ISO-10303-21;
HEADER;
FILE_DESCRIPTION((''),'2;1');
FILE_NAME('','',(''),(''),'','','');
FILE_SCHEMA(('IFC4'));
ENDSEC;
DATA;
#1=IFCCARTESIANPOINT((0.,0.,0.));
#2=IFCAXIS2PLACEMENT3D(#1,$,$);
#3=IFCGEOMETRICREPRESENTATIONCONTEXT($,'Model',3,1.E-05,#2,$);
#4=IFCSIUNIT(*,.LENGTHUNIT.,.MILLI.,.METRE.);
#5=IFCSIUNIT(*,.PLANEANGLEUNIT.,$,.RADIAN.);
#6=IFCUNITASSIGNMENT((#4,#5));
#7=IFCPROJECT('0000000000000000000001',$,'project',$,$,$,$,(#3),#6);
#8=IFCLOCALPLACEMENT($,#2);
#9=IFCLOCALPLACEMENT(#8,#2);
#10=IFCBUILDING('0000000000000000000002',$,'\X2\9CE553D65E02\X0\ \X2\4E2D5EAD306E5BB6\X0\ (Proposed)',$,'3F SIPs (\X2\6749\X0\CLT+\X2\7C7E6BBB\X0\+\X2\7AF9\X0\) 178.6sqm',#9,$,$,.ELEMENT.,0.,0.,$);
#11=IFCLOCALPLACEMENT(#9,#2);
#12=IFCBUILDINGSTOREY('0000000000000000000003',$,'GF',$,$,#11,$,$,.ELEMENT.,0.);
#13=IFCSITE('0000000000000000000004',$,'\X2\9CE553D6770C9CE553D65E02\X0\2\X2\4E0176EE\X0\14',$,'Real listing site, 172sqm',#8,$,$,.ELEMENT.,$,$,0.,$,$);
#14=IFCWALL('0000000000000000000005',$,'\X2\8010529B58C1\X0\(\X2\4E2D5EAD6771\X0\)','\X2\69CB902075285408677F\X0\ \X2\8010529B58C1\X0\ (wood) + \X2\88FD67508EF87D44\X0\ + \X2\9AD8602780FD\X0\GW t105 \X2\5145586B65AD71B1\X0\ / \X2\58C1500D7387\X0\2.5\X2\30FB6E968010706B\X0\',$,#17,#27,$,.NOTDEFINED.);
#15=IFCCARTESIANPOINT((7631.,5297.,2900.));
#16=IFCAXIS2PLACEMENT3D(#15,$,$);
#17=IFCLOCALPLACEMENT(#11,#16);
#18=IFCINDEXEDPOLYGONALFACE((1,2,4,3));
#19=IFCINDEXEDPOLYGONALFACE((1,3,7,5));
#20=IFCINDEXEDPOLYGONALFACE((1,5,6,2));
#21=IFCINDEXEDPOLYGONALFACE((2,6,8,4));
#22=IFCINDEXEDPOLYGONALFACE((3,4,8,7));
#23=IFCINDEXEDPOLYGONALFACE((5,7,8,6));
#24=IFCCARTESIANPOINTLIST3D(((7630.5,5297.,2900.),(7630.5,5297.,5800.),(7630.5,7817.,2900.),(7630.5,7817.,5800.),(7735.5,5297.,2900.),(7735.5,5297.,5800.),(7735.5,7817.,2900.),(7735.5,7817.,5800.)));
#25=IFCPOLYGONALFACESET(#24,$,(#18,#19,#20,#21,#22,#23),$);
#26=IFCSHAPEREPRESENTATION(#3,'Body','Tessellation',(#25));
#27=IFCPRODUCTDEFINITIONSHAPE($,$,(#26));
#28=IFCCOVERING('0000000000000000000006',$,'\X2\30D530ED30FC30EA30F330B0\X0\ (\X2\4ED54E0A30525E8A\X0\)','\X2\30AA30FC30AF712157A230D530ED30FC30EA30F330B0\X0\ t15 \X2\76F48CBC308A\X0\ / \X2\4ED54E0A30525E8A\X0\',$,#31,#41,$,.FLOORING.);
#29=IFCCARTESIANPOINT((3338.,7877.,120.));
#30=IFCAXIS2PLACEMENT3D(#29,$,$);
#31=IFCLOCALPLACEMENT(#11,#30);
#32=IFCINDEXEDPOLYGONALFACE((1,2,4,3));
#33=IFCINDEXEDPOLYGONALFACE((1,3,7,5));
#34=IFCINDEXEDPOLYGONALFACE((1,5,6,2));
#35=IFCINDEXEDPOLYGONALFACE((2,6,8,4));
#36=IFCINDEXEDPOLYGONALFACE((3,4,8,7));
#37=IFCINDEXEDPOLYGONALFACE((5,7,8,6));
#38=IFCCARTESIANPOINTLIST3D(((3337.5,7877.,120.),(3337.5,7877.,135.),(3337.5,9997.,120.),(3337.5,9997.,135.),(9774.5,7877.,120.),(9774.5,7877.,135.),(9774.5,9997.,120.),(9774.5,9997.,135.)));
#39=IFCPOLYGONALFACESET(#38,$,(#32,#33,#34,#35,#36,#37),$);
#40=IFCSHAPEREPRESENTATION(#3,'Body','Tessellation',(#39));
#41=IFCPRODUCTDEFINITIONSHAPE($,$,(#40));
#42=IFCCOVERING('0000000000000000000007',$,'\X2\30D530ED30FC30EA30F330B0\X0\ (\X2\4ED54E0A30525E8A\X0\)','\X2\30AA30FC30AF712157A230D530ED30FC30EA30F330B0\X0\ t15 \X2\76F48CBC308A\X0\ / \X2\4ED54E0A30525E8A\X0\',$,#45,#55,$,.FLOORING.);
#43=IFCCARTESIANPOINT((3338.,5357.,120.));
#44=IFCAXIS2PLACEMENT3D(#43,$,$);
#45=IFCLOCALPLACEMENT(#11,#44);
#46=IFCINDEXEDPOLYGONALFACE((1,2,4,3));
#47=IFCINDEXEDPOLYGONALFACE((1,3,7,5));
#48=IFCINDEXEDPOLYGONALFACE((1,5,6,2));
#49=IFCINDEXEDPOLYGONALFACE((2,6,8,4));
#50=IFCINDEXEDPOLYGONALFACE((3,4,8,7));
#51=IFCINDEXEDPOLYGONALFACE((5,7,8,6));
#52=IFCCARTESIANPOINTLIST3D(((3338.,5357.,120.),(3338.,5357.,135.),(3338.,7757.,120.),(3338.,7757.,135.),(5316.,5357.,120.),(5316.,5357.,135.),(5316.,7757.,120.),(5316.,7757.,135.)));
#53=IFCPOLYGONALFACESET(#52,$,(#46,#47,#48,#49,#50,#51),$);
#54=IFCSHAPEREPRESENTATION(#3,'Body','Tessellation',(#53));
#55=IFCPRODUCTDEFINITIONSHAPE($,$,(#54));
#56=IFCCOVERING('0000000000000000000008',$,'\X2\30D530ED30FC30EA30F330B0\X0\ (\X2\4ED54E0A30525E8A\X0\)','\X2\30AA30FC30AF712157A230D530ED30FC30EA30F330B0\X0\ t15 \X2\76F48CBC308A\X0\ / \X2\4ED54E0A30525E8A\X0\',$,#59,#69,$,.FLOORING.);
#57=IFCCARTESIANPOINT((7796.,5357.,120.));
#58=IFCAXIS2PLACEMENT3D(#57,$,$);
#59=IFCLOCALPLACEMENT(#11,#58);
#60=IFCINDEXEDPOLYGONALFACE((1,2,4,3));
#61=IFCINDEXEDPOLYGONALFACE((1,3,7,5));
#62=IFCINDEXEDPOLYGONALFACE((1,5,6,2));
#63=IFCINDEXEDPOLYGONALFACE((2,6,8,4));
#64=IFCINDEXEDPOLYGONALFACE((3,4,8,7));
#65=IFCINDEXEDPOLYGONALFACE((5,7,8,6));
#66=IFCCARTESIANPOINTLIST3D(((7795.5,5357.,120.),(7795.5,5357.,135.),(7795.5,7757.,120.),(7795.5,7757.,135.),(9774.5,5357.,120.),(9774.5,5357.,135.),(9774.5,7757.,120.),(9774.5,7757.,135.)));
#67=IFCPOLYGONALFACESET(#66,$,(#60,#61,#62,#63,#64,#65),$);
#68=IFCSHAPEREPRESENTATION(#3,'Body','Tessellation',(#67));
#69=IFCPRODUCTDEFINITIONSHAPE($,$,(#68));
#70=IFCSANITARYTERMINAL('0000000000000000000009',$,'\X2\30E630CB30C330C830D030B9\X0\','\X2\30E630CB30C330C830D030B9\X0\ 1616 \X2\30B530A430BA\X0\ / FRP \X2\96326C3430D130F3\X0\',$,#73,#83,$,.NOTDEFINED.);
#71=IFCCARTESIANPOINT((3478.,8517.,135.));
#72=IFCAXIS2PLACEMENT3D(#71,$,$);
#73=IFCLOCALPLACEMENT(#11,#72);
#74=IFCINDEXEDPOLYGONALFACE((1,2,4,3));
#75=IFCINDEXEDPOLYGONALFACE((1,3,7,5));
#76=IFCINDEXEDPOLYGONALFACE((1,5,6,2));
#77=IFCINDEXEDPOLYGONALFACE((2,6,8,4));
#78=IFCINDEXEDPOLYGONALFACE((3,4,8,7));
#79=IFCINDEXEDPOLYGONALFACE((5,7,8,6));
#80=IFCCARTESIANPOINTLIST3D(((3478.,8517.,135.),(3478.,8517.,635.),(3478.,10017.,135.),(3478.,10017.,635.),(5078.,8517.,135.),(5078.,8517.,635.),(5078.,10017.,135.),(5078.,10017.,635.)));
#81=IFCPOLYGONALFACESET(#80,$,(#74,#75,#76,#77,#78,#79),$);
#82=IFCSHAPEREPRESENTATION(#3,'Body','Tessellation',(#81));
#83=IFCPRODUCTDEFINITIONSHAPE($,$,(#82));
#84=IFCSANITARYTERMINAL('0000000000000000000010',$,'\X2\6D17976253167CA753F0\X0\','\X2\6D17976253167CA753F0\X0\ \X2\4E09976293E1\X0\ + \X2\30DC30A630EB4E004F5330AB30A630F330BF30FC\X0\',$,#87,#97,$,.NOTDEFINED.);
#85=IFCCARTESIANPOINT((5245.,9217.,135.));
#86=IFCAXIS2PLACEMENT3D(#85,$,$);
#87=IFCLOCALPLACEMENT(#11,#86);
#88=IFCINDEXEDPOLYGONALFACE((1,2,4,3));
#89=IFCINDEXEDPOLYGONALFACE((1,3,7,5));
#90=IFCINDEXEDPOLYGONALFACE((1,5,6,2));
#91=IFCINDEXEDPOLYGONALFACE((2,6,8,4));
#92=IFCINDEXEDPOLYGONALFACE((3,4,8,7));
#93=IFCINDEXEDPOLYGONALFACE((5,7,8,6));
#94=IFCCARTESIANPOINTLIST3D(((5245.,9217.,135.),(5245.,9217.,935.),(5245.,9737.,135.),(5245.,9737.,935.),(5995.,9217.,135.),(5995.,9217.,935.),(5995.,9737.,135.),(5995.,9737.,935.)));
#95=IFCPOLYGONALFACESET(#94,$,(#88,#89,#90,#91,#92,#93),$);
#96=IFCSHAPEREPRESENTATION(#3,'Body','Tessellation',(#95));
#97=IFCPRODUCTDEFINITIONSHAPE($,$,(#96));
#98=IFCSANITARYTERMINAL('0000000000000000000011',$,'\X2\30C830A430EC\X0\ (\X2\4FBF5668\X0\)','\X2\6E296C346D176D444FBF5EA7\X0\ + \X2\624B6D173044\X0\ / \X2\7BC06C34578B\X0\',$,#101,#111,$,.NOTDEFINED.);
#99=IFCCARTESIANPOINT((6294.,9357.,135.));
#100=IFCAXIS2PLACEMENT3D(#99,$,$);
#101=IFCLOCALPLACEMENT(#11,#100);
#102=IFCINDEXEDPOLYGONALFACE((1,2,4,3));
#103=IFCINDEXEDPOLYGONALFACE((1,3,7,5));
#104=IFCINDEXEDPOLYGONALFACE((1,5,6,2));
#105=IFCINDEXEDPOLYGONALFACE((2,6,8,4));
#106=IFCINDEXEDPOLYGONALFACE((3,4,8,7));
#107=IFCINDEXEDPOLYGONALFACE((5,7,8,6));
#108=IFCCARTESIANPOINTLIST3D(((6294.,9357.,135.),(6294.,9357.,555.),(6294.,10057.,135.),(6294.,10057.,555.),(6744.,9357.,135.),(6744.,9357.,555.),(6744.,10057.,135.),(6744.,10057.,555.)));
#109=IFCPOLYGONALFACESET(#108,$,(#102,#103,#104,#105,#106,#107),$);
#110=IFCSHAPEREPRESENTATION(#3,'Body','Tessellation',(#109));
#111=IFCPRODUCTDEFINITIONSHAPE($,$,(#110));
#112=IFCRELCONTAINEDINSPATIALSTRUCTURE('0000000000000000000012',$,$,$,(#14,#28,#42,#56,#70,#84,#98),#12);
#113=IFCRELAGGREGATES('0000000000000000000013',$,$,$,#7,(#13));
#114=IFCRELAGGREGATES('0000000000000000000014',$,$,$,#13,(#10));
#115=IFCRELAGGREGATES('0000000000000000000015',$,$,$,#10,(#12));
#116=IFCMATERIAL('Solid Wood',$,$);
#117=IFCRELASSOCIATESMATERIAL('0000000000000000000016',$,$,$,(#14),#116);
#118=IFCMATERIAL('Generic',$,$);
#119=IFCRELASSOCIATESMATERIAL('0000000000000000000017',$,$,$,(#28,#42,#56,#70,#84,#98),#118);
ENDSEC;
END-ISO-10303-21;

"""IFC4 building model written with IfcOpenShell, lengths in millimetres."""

from ifc_helpers import new_model, si_unit, frame, frame_2d, origin, place, context, project, spatial, rectangle, extrude, material, element, save


model = new_model("IFC4")

# Units and contexts
model_context = context("Model", 3, precision=1e-05, world=origin())
ifc_project = project(units=[si_unit("LENGTHUNIT", "METRE", prefix="MILLI"), si_unit("PLANEANGLEUNIT", "RADIAN")], contexts=[model_context])

# Site, building, storey
site_placement = place(None, origin())
site = spatial("IfcSite", under=ifc_project, at=site_placement, Name="鳥取県鳥取市2丁目14", ObjectType="Real listing site, 172sqm", CompositionType="ELEMENT", RefElevation=0.0)
building_placement = place(site_placement, origin())
building = spatial("IfcBuilding", under=site, at=building_placement, Name="鳥取市 中庭の家 (Proposed)", ObjectType="3F SIPs (杉CLT+籾殻+竹) 178.6sqm", CompositionType="ELEMENT", ElevationOfRefHeight=0.0, ElevationOfTerrain=0.0)
storey_placement = place(building_placement, origin())
storey = spatial("IfcBuildingStorey", under=building, at=storey_placement, Name="GF", CompositionType="ELEMENT", Elevation=0.0)

# Shared definitions
ifc_material_1 = material(Name="Solid Wood")

# Wall
wall_1_placement = place(storey_placement, frame((7631.0, 5297.0, 2900.0)))
element("IfcWall", 1, at=wall_1_placement, inside=storey, material=ifc_material_1, Name="耐力壁(中庭東)", Description="構造用合板 耐力壁 (wood) + 製材軸組 + 高性能GW t105 充填断熱 / 壁倍率2.5・準耐火", PredefinedType="NOTDEFINED", context=model_context, shape_type="SweptSolid", body=[
    extrude(rectangle(XDim=105.0, YDim=2520.0, at=frame_2d((52.0, 1260.0))), frame((7631.0, 5297.0, 2900.0)), (0.0, 0.0, 1.0), 2900.0),
])

# Coverings
ifc_material_2 = material(Name="Generic")
covering_1_placement = place(storey_placement, frame((3338.0, 7877.0, 120.0)))
element("IfcCovering", 2, at=covering_1_placement, inside=storey, material=ifc_material_2, Name="フローリング (仕上げ床)", Description="オーク無垢フローリング t15 直貼り / 仕上げ床", PredefinedType="FLOORING", context=model_context, shape_type="SweptSolid", body=[
    extrude(rectangle(XDim=6437.0, YDim=2120.0, at=frame_2d((3218.0, 1060.0))), frame((3338.0, 7877.0, 120.0)), (0.0, 0.0, 1.0), 15.0),
])
covering_2_placement = place(storey_placement, frame((3338.0, 5357.0, 120.0)))
element("IfcCovering", 3, at=covering_2_placement, inside=storey, material=ifc_material_2, Name="フローリング (仕上げ床)", Description="オーク無垢フローリング t15 直貼り / 仕上げ床", PredefinedType="FLOORING", context=model_context, shape_type="SweptSolid", body=[
    extrude(rectangle(XDim=1978.0, YDim=2400.0, at=frame_2d((989.0, 1200.0))), frame((3338.0, 5357.0, 120.0)), (0.0, 0.0, 1.0), 15.0),
])
covering_3_placement = place(storey_placement, frame((7796.0, 5357.0, 120.0)))
element("IfcCovering", 4, at=covering_3_placement, inside=storey, material=ifc_material_2, Name="フローリング (仕上げ床)", Description="オーク無垢フローリング t15 直貼り / 仕上げ床", PredefinedType="FLOORING", context=model_context, shape_type="SweptSolid", body=[
    extrude(rectangle(XDim=1979.0, YDim=2400.0, at=frame_2d((989.0, 1200.0))), frame((7796.0, 5357.0, 120.0)), (0.0, 0.0, 1.0), 15.0),
])

# Sanitary terminals
sanitary_terminal_1_placement = place(storey_placement, frame((3478.0, 8517.0, 135.0)))
element("IfcSanitaryTerminal", 5, at=sanitary_terminal_1_placement, inside=storey, material=ifc_material_2, Name="ユニットバス", Description="ユニットバス 1616 サイズ / FRP 防水パン", PredefinedType="NOTDEFINED", context=model_context, shape_type="SweptSolid", body=[
    extrude(rectangle(XDim=1600.0, YDim=1500.0, at=frame_2d((800.0, 750.0))), frame((3478.0, 8517.0, 135.0)), (0.0, 0.0, 1.0), 500.0),
])
sanitary_terminal_2_placement = place(storey_placement, frame((5245.0, 9217.0, 135.0)))
element("IfcSanitaryTerminal", 6, at=sanitary_terminal_2_placement, inside=storey, material=ifc_material_2, Name="洗面化粧台", Description="洗面化粧台 三面鏡 + ボウル一体カウンター", PredefinedType="NOTDEFINED", context=model_context, shape_type="SweptSolid", body=[
    extrude(rectangle(XDim=750.0, YDim=520.0, at=frame_2d((375.0, 260.0))), frame((5245.0, 9217.0, 135.0)), (0.0, 0.0, 1.0), 800.0),
])
sanitary_terminal_3_placement = place(storey_placement, frame((6294.0, 9357.0, 135.0)))
element("IfcSanitaryTerminal", 7, at=sanitary_terminal_3_placement, inside=storey, material=ifc_material_2, Name="トイレ (便器)", Description="温水洗浄便座 + 手洗い / 節水型", PredefinedType="NOTDEFINED", context=model_context, shape_type="SweptSolid", body=[
    extrude(rectangle(XDim=450.0, YDim=700.0, at=frame_2d((225.0, 350.0))), frame((6294.0, 9357.0, 135.0)), (0.0, 0.0, 1.0), 420.0),
])

save(model, "model.ifc")
